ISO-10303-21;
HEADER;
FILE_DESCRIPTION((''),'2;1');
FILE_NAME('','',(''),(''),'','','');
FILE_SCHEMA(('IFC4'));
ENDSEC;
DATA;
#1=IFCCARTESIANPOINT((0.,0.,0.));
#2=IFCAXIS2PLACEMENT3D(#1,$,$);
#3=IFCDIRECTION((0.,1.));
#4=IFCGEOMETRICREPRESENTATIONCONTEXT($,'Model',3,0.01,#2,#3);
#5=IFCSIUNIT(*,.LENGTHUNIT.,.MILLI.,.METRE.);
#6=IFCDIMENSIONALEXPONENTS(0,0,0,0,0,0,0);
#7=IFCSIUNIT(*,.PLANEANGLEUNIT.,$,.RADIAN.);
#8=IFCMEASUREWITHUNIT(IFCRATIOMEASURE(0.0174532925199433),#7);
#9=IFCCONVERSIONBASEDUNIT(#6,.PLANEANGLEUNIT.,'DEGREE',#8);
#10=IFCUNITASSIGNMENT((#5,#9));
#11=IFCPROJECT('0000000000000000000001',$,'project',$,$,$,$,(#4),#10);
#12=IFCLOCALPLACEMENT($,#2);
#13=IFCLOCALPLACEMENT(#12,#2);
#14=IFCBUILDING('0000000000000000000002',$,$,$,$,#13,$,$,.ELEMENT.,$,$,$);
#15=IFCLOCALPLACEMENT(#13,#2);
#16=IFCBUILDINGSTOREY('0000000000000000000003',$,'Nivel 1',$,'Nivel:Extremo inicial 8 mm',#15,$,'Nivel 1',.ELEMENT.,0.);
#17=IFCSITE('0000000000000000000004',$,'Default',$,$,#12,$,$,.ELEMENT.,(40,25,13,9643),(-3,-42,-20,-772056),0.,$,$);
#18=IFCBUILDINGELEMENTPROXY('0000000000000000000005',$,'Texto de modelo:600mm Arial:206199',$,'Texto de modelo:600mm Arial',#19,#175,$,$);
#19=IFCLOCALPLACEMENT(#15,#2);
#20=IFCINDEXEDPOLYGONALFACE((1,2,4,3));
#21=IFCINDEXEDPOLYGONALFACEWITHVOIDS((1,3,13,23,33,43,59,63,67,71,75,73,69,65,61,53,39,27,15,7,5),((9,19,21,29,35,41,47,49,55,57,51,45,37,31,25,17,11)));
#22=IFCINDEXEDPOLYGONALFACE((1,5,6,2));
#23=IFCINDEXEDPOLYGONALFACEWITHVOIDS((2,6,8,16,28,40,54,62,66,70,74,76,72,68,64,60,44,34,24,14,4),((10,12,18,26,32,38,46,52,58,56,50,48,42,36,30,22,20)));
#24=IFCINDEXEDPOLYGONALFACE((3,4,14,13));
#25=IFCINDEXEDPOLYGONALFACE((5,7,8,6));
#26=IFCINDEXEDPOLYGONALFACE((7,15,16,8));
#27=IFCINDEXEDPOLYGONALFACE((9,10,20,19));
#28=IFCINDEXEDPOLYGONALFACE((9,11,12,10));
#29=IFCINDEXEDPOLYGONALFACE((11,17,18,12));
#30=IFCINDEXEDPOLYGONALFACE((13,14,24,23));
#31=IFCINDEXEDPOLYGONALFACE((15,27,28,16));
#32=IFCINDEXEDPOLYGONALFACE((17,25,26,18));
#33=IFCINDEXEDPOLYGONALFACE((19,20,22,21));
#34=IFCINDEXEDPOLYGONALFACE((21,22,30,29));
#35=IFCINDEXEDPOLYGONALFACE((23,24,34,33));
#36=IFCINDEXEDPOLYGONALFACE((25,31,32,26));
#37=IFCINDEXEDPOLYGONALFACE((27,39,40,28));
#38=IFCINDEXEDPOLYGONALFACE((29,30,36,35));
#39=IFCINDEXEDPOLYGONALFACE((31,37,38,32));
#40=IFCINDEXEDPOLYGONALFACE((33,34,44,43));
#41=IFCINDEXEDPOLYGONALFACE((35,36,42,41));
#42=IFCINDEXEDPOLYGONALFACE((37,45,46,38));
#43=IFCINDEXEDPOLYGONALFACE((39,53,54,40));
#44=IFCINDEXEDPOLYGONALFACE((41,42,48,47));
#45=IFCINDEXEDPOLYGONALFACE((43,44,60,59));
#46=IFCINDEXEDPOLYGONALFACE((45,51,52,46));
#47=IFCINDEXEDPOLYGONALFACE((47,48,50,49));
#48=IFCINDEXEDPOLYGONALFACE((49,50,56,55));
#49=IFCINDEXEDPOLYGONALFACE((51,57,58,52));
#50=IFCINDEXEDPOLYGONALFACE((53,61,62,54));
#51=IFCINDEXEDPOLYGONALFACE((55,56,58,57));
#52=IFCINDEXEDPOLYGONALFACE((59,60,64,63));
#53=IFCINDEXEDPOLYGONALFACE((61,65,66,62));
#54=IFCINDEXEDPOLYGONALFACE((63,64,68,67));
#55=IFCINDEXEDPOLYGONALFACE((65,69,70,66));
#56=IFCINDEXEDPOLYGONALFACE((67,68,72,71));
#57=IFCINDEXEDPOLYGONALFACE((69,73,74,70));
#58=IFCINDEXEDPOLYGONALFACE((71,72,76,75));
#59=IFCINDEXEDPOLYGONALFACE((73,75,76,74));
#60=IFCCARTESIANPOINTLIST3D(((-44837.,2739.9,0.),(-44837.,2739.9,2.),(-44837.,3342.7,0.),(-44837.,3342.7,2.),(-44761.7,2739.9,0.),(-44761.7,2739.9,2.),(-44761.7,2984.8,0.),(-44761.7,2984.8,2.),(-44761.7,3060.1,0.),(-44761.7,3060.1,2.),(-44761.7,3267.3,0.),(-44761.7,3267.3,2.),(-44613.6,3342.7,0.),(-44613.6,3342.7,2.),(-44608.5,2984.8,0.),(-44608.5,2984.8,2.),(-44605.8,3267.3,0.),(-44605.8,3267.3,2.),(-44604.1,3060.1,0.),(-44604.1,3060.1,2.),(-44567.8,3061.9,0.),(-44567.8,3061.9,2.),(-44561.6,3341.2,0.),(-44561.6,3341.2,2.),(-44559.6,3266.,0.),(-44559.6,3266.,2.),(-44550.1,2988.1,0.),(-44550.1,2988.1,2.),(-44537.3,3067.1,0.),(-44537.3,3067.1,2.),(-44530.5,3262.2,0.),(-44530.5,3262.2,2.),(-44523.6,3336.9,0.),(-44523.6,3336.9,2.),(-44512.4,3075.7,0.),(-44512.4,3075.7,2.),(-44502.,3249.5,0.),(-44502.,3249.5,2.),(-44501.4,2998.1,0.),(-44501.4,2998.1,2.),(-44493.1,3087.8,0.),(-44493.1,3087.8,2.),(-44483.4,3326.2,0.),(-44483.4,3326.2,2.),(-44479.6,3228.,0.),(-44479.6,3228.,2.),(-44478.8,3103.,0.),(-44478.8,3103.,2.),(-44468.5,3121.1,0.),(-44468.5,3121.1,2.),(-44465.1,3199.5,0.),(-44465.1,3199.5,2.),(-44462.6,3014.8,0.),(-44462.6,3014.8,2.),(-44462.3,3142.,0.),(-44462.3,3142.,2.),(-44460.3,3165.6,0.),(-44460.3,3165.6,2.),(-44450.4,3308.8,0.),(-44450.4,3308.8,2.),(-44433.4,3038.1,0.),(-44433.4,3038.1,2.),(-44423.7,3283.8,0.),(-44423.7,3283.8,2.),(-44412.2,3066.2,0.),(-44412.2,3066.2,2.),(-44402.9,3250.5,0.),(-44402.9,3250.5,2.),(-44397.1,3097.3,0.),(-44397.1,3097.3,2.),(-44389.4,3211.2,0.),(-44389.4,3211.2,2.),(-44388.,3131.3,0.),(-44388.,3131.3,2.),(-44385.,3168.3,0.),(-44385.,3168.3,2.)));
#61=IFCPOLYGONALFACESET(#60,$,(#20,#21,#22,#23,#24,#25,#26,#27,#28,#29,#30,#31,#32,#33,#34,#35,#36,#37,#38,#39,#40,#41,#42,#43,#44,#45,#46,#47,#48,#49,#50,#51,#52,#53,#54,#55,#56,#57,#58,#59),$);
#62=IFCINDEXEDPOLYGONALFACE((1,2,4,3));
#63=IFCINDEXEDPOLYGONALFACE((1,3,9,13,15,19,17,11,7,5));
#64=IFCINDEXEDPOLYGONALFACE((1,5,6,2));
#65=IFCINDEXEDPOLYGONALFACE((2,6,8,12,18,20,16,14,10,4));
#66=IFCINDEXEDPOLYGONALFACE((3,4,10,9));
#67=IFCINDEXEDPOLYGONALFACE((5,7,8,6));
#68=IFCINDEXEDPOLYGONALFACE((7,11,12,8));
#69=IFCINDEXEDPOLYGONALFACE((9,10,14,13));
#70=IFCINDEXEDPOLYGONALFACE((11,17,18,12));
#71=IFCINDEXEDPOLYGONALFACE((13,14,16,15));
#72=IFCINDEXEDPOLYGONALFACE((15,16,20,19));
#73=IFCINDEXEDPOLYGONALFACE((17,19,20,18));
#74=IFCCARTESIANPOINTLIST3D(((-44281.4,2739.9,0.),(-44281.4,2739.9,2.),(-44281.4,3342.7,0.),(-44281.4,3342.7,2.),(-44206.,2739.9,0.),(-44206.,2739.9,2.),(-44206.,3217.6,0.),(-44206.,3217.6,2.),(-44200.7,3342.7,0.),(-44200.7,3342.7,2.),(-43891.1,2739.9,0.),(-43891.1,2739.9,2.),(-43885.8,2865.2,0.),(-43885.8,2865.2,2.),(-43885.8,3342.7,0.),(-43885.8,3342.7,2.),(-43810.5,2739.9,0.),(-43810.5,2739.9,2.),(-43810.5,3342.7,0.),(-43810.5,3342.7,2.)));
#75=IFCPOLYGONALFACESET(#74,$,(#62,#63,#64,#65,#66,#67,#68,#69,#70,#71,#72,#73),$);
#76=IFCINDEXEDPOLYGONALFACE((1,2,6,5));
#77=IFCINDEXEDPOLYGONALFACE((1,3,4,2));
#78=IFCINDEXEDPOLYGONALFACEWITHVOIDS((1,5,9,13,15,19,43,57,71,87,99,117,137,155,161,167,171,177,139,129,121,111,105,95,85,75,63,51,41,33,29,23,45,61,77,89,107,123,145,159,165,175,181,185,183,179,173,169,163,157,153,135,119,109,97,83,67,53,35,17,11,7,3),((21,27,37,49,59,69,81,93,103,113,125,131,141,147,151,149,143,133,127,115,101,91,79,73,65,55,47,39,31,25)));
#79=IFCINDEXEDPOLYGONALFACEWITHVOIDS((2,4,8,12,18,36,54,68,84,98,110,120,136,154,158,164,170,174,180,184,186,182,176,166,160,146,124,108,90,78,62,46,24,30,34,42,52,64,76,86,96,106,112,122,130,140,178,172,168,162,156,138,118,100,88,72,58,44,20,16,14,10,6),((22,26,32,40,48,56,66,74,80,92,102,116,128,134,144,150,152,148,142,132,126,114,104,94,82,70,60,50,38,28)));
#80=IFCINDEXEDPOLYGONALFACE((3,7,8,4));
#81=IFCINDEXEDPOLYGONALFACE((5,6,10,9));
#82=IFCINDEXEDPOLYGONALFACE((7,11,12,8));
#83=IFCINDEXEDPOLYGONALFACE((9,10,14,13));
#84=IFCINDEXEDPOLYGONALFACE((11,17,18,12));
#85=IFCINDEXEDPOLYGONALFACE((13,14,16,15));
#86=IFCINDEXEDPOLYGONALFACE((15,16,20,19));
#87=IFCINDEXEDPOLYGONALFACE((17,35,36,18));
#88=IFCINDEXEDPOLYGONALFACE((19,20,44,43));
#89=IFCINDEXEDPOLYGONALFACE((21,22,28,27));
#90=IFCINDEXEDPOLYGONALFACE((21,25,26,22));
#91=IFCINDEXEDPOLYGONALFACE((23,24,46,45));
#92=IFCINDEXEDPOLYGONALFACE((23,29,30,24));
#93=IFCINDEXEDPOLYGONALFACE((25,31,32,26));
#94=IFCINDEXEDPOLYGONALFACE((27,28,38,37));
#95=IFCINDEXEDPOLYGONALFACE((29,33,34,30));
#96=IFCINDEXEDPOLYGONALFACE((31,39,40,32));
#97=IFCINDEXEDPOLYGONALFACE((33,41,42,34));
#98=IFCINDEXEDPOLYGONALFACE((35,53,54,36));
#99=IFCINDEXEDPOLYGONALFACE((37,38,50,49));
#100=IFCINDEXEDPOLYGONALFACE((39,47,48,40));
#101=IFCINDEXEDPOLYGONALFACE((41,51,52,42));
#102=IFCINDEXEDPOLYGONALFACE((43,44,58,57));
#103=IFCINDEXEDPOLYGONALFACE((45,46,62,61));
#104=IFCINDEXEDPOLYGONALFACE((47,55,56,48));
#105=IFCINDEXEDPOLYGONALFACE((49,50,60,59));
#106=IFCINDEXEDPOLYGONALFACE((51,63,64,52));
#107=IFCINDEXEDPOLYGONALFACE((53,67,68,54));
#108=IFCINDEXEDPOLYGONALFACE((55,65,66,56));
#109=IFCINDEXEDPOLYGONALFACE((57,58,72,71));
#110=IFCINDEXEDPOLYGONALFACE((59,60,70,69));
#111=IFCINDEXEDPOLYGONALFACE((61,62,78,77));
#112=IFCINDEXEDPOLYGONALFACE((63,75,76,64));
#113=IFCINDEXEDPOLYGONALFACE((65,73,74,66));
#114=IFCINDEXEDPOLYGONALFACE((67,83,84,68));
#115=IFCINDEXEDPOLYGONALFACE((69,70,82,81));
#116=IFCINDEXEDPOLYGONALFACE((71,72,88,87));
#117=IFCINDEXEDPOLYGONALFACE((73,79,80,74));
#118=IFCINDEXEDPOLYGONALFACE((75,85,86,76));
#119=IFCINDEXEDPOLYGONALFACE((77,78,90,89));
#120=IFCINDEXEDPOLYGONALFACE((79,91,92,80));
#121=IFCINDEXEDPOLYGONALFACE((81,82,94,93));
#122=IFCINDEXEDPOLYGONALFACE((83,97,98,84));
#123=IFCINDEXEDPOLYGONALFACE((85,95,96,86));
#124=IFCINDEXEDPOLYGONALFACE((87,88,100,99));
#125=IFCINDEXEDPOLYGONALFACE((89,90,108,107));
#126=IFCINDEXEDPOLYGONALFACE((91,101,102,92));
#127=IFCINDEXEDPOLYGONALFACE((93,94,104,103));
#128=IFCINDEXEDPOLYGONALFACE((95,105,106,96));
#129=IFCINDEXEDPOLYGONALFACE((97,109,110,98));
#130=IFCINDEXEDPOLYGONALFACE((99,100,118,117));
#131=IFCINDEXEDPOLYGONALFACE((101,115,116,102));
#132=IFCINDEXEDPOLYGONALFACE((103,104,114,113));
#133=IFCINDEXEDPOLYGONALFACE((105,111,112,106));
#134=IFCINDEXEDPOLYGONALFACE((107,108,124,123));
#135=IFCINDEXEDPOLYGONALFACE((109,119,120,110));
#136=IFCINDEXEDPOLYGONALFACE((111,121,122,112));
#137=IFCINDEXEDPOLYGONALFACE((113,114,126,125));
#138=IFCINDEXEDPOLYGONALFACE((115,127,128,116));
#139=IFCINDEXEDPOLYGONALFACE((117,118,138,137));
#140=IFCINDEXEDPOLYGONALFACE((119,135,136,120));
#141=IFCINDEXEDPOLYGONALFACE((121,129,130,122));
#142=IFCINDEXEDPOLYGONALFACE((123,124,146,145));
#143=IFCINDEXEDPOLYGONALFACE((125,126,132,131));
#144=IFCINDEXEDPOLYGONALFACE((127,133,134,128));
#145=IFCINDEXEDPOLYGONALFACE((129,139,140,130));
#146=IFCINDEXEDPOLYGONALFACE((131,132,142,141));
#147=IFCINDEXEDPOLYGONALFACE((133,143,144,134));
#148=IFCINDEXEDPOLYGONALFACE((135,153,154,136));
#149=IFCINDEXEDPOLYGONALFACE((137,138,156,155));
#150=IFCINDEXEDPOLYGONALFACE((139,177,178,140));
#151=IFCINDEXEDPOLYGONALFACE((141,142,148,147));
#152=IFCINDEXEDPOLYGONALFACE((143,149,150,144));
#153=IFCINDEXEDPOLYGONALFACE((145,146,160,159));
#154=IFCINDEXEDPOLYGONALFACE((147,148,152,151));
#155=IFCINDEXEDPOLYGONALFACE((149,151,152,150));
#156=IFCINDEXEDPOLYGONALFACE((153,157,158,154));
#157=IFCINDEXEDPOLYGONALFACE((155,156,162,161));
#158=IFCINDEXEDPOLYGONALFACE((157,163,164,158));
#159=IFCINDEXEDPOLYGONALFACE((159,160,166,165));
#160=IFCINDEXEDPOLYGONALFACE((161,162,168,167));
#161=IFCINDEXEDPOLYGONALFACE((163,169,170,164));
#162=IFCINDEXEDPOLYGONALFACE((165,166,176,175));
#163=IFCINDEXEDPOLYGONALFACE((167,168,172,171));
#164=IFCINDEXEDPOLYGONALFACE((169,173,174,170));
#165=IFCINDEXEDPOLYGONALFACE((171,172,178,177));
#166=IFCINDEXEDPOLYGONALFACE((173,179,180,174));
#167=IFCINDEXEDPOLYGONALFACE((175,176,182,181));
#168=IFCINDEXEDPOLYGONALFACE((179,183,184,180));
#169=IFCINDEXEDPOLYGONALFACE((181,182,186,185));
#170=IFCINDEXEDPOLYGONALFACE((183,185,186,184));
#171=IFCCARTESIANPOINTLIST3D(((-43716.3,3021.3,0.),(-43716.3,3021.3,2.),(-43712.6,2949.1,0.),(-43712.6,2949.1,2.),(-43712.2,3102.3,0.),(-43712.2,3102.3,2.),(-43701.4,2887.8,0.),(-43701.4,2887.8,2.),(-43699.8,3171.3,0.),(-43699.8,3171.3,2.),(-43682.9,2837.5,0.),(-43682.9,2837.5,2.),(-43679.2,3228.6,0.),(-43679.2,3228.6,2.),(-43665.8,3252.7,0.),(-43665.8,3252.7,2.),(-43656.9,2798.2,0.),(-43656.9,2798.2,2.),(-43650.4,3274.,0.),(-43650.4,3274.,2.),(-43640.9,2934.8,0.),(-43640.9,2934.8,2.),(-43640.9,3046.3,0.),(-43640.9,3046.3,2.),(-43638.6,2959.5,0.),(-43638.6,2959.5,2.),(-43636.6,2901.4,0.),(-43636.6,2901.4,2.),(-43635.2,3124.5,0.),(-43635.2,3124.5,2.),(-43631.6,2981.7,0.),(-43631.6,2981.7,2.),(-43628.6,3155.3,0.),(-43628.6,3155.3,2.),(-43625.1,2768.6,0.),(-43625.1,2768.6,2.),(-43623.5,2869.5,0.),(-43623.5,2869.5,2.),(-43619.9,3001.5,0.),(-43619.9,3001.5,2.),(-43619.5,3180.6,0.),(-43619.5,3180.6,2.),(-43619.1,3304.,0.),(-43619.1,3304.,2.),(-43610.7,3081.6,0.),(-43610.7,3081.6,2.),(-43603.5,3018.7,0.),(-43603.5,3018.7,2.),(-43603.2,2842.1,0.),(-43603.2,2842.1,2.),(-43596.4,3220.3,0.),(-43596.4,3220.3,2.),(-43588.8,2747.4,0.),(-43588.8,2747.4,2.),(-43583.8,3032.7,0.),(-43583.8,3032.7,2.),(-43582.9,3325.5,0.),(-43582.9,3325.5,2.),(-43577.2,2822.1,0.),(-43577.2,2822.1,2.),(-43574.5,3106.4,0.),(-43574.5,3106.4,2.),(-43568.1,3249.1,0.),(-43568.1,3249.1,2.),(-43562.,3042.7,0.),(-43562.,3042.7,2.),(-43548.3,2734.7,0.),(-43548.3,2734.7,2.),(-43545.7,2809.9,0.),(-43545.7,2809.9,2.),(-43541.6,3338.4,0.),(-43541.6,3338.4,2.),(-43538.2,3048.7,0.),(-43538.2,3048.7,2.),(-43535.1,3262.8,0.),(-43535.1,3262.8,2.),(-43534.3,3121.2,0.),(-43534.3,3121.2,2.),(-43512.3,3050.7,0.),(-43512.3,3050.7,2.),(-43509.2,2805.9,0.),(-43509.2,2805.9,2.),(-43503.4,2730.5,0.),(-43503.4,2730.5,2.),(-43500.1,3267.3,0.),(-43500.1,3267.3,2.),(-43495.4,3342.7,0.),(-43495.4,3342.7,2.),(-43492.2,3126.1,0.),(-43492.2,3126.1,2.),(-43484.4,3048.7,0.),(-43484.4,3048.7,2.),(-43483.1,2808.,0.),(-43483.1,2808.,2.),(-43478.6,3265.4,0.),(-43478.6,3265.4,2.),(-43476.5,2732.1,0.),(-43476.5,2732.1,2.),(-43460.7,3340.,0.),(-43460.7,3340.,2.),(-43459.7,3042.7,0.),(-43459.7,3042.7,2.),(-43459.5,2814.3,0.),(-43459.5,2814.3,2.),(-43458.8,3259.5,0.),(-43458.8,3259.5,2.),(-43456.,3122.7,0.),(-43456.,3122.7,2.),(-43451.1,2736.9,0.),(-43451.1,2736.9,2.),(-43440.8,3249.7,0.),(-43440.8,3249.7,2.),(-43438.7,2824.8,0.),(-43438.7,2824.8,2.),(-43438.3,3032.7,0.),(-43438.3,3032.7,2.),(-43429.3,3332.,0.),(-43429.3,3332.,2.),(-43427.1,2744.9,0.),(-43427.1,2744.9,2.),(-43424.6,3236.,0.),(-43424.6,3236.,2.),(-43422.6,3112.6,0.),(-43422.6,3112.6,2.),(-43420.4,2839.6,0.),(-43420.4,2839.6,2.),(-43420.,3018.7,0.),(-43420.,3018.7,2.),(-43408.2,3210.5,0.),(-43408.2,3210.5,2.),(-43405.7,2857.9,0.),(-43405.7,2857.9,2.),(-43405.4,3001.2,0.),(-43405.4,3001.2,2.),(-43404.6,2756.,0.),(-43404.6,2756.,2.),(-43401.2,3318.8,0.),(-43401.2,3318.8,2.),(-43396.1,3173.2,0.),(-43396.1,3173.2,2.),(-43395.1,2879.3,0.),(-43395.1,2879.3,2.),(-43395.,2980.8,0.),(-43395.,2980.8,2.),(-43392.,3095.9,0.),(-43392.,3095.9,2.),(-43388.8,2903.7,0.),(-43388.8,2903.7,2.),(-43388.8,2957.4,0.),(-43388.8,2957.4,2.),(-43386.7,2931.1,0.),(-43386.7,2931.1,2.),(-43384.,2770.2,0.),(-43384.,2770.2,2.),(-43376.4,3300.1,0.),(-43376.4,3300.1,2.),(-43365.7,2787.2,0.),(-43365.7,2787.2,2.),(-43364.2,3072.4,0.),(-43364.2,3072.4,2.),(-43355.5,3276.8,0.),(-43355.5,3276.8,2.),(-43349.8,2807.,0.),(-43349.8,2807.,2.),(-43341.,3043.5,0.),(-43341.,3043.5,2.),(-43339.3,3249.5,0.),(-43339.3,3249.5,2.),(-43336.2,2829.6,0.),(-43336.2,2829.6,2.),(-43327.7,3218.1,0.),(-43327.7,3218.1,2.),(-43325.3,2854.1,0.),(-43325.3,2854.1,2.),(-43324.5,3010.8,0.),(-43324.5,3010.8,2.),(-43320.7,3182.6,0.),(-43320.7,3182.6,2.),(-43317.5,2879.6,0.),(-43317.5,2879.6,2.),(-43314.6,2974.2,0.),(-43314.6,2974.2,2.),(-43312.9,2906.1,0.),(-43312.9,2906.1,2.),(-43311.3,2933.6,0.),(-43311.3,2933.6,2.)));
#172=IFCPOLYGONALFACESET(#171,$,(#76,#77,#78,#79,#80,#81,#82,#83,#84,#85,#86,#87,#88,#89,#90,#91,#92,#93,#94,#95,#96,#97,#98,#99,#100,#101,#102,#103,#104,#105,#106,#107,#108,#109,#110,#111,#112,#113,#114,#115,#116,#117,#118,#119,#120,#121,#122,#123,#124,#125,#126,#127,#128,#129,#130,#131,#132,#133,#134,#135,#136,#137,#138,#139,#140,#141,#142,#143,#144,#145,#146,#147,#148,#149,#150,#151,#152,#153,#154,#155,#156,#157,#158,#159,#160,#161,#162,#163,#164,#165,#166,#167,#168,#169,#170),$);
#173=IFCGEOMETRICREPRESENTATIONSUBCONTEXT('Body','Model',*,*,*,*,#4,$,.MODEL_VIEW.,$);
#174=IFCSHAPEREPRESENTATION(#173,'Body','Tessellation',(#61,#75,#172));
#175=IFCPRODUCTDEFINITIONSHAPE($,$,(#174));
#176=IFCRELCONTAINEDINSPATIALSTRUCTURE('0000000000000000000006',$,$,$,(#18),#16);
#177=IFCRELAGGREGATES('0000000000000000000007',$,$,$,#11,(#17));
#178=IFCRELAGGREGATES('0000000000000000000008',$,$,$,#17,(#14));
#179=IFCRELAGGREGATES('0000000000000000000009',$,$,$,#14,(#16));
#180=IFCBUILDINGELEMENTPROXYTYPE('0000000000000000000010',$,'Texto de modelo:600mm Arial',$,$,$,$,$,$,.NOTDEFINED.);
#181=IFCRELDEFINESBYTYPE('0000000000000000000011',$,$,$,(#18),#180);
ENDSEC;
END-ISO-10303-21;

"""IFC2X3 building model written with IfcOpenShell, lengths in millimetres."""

from ifc_helpers import new_model, entity, si_unit, converted_unit, direction, frame, origin, place, context, subcontext, project, spatial, polyline, outline, extrude, type_object, element, save


model = new_model("IFC2X3")

# Units and contexts
model_context = context("Model", 3, precision=0.01, world=origin(), true_north=direction((0.0, 1.0)))
body_context = subcontext(model_context, "Body", "Model", "MODEL_VIEW")
ifc_project = project(units=[si_unit("LENGTHUNIT", "METRE", prefix="MILLI"), converted_unit("PLANEANGLEUNIT", "DEGREE", entity("IfcRatioMeasure", 0.0174532925199433), si_unit("PLANEANGLEUNIT", "RADIAN"), dimensions=[0, 0, 0, 0, 0, 0, 0])], contexts=[model_context])

# Site, building, storey
site_placement = place(None, origin())
site = spatial("IfcSite", under=ifc_project, at=site_placement, Name="Default", CompositionType="ELEMENT", RefLatitude=(40, 25, 13, 9643), RefLongitude=(-3, -42, -20, -772056), RefElevation=0.0)
building_placement = place(site_placement, origin())
building = spatial("IfcBuilding", under=site, at=building_placement, CompositionType="ELEMENT")
storey_placement = place(building_placement, origin())
storey = spatial("IfcBuildingStorey", under=building, at=storey_placement, Name="Nivel 1", ObjectType="Nivel:Extremo inicial 8 mm", LongName="Nivel 1", CompositionType="ELEMENT", Elevation=0.0)

# Building element proxy
building_element_proxy_type_1 = type_object("IfcBuildingElementProxyType", Name="Texto de modelo:600mm Arial", PredefinedType="NOTDEFINED")
proxy_1_placement = place(storey_placement, frame((-44837.0, 2730.5, 0.0)))
element("IfcBuildingElementProxy", 1, at=proxy_1_placement, inside=storey, type_object=building_element_proxy_type_1, Name="Texto de modelo:600mm Arial:206199", ObjectType="Texto de modelo:600mm Arial", context=body_context, shape_type="SweptSolid", body=[
    extrude(outline(polyline([(-304.4, -388.4), (-229.1, -388.4), (-229.1, -143.6), (-75.9, -143.6), (-17.5, -140.2), (31.1, -130.2), (70.0, -113.6), (99.1, -90.3), (120.4, -62.2), (135.5, -31.1), (144.6, 2.9), (147.6, 39.9), (143.1, 82.9), (129.7, 122.1), (108.8, 155.4), (82.2, 180.4), (49.2, 197.9), (9.0, 208.6), (-29.0, 212.9), (-81.0, 214.3), (-304.4, 214.3), (-304.4, -388.4)]), holes=[polyline([(-229.1, -68.2), (-229.1, 139.0), (-73.2, 139.0), (-27.0, 137.7), (2.1, 133.8), (30.6, 121.2), (52.9, 99.7), (67.5, 71.1), (72.3, 37.3), (70.2, 13.6), (64.1, -7.3), (53.8, -25.3), (39.5, -40.6), (20.2, -52.7), (-4.7, -61.3), (-35.2, -66.5), (-71.5, -68.2), (-229.1, -68.2)])]), frame((304.4, 397.8, 0.0)), (0.0, 0.0, 1.0), 2.0),
    extrude(outline(polyline([(-235.4, -301.4), (-160.1, -301.4), (-160.1, 176.3), (154.8, -301.4), (235.4, -301.4), (235.4, 301.4), (160.1, 301.4), (160.1, -176.2), (-154.8, 301.4), (-235.4, 301.4), (-235.4, -301.4)])), frame((791.1, 310.8, 0.0)), (0.0, 0.0, 1.0), 2.0),
    extrude(outline(polyline([(75.5, -189.6), (111.7, -189.6), (144.7, -184.2), (174.7, -173.6), (201.6, -157.6), (224.6, -136.8), (243.1, -111.8), (256.9, -82.5), (266.2, -48.9), (270.9, -2.8), (266.2, 40.2), (252.0, 79.9), (228.6, 116.3), (210.7, 135.6), (189.6, 153.4), (137.4, 184.6), (71.9, 210.0), (-6.7, 229.6), (-78.3, 239.8), (-140.6, 240.7), (-193.5, 232.2), (-237.1, 214.2), (-272.2, 188.6), (-300.0, 157.2), (-320.2, 119.8), (-333.0, 76.5), (-336.6, 49.9), (-336.8, 24.0), (-333.6, -1.0), (-326.9, -25.3), (-317.0, -48.2), (-303.8, -69.4), (-287.5, -88.9), (-267.9, -106.6), (-245.9, -121.9), (-222.4, -134.5), (-197.3, -144.1), (-170.6, -150.9), (-130.2, -155.5), (-92.3, -152.8), (-57.0, -142.9), (-24.3, -125.8), (4.1, -103.0), (26.5, -76.2), (42.8, -45.4), (53.0, -10.5), (56.3, 31.8), (49.6, 74.1), (32.1, 114.4), (3.3, 150.9), (78.9, 130.1), (107.9, 117.8), (131.0, 104.0), (165.5, 73.7), (188.3, 40.4), (195.4, 5.4), (193.2, -29.8), (187.1, -50.6), (177.5, -68.9), (164.5, -84.6), (147.9, -97.9), (119.7, -109.1), (80.7, -113.8), (75.5, -189.6)]), holes=[polyline([(-106.1, 172.3), (-82.3, 165.2), (-61.8, 154.1), (-44.7, 138.8), (-30.9, 119.4), (-21.0, 97.3), (-15.4, 74.1), (-14.0, 49.5), (-17.0, 23.8), (-24.4, -3.2), (-35.0, -26.3), (-49.0, -45.4), (-66.2, -60.7), (-86.2, -71.6), (-108.2, -77.9), (-132.4, -79.6), (-158.6, -76.5), (-185.1, -69.2), (-207.8, -58.3), (-226.8, -43.8), (-241.9, -25.8), (-252.9, -5.1), (-259.2, 17.4), (-260.9, 41.7), (-257.9, 67.8), (-246.9, 102.8), (-228.9, 131.4), (-204.3, 153.1), (-173.5, 167.7), (-139.7, 174.4), (-106.1, 172.3)])]), frame((1344.7, 341.5, 0.0), z_axis=(0.0, 0.0, 1.0), x_axis=(-0.192251, 0.981346, 0.0)), (0.0, 0.0, 1.0), 2.0),
])

save(model, "model.ifc")
